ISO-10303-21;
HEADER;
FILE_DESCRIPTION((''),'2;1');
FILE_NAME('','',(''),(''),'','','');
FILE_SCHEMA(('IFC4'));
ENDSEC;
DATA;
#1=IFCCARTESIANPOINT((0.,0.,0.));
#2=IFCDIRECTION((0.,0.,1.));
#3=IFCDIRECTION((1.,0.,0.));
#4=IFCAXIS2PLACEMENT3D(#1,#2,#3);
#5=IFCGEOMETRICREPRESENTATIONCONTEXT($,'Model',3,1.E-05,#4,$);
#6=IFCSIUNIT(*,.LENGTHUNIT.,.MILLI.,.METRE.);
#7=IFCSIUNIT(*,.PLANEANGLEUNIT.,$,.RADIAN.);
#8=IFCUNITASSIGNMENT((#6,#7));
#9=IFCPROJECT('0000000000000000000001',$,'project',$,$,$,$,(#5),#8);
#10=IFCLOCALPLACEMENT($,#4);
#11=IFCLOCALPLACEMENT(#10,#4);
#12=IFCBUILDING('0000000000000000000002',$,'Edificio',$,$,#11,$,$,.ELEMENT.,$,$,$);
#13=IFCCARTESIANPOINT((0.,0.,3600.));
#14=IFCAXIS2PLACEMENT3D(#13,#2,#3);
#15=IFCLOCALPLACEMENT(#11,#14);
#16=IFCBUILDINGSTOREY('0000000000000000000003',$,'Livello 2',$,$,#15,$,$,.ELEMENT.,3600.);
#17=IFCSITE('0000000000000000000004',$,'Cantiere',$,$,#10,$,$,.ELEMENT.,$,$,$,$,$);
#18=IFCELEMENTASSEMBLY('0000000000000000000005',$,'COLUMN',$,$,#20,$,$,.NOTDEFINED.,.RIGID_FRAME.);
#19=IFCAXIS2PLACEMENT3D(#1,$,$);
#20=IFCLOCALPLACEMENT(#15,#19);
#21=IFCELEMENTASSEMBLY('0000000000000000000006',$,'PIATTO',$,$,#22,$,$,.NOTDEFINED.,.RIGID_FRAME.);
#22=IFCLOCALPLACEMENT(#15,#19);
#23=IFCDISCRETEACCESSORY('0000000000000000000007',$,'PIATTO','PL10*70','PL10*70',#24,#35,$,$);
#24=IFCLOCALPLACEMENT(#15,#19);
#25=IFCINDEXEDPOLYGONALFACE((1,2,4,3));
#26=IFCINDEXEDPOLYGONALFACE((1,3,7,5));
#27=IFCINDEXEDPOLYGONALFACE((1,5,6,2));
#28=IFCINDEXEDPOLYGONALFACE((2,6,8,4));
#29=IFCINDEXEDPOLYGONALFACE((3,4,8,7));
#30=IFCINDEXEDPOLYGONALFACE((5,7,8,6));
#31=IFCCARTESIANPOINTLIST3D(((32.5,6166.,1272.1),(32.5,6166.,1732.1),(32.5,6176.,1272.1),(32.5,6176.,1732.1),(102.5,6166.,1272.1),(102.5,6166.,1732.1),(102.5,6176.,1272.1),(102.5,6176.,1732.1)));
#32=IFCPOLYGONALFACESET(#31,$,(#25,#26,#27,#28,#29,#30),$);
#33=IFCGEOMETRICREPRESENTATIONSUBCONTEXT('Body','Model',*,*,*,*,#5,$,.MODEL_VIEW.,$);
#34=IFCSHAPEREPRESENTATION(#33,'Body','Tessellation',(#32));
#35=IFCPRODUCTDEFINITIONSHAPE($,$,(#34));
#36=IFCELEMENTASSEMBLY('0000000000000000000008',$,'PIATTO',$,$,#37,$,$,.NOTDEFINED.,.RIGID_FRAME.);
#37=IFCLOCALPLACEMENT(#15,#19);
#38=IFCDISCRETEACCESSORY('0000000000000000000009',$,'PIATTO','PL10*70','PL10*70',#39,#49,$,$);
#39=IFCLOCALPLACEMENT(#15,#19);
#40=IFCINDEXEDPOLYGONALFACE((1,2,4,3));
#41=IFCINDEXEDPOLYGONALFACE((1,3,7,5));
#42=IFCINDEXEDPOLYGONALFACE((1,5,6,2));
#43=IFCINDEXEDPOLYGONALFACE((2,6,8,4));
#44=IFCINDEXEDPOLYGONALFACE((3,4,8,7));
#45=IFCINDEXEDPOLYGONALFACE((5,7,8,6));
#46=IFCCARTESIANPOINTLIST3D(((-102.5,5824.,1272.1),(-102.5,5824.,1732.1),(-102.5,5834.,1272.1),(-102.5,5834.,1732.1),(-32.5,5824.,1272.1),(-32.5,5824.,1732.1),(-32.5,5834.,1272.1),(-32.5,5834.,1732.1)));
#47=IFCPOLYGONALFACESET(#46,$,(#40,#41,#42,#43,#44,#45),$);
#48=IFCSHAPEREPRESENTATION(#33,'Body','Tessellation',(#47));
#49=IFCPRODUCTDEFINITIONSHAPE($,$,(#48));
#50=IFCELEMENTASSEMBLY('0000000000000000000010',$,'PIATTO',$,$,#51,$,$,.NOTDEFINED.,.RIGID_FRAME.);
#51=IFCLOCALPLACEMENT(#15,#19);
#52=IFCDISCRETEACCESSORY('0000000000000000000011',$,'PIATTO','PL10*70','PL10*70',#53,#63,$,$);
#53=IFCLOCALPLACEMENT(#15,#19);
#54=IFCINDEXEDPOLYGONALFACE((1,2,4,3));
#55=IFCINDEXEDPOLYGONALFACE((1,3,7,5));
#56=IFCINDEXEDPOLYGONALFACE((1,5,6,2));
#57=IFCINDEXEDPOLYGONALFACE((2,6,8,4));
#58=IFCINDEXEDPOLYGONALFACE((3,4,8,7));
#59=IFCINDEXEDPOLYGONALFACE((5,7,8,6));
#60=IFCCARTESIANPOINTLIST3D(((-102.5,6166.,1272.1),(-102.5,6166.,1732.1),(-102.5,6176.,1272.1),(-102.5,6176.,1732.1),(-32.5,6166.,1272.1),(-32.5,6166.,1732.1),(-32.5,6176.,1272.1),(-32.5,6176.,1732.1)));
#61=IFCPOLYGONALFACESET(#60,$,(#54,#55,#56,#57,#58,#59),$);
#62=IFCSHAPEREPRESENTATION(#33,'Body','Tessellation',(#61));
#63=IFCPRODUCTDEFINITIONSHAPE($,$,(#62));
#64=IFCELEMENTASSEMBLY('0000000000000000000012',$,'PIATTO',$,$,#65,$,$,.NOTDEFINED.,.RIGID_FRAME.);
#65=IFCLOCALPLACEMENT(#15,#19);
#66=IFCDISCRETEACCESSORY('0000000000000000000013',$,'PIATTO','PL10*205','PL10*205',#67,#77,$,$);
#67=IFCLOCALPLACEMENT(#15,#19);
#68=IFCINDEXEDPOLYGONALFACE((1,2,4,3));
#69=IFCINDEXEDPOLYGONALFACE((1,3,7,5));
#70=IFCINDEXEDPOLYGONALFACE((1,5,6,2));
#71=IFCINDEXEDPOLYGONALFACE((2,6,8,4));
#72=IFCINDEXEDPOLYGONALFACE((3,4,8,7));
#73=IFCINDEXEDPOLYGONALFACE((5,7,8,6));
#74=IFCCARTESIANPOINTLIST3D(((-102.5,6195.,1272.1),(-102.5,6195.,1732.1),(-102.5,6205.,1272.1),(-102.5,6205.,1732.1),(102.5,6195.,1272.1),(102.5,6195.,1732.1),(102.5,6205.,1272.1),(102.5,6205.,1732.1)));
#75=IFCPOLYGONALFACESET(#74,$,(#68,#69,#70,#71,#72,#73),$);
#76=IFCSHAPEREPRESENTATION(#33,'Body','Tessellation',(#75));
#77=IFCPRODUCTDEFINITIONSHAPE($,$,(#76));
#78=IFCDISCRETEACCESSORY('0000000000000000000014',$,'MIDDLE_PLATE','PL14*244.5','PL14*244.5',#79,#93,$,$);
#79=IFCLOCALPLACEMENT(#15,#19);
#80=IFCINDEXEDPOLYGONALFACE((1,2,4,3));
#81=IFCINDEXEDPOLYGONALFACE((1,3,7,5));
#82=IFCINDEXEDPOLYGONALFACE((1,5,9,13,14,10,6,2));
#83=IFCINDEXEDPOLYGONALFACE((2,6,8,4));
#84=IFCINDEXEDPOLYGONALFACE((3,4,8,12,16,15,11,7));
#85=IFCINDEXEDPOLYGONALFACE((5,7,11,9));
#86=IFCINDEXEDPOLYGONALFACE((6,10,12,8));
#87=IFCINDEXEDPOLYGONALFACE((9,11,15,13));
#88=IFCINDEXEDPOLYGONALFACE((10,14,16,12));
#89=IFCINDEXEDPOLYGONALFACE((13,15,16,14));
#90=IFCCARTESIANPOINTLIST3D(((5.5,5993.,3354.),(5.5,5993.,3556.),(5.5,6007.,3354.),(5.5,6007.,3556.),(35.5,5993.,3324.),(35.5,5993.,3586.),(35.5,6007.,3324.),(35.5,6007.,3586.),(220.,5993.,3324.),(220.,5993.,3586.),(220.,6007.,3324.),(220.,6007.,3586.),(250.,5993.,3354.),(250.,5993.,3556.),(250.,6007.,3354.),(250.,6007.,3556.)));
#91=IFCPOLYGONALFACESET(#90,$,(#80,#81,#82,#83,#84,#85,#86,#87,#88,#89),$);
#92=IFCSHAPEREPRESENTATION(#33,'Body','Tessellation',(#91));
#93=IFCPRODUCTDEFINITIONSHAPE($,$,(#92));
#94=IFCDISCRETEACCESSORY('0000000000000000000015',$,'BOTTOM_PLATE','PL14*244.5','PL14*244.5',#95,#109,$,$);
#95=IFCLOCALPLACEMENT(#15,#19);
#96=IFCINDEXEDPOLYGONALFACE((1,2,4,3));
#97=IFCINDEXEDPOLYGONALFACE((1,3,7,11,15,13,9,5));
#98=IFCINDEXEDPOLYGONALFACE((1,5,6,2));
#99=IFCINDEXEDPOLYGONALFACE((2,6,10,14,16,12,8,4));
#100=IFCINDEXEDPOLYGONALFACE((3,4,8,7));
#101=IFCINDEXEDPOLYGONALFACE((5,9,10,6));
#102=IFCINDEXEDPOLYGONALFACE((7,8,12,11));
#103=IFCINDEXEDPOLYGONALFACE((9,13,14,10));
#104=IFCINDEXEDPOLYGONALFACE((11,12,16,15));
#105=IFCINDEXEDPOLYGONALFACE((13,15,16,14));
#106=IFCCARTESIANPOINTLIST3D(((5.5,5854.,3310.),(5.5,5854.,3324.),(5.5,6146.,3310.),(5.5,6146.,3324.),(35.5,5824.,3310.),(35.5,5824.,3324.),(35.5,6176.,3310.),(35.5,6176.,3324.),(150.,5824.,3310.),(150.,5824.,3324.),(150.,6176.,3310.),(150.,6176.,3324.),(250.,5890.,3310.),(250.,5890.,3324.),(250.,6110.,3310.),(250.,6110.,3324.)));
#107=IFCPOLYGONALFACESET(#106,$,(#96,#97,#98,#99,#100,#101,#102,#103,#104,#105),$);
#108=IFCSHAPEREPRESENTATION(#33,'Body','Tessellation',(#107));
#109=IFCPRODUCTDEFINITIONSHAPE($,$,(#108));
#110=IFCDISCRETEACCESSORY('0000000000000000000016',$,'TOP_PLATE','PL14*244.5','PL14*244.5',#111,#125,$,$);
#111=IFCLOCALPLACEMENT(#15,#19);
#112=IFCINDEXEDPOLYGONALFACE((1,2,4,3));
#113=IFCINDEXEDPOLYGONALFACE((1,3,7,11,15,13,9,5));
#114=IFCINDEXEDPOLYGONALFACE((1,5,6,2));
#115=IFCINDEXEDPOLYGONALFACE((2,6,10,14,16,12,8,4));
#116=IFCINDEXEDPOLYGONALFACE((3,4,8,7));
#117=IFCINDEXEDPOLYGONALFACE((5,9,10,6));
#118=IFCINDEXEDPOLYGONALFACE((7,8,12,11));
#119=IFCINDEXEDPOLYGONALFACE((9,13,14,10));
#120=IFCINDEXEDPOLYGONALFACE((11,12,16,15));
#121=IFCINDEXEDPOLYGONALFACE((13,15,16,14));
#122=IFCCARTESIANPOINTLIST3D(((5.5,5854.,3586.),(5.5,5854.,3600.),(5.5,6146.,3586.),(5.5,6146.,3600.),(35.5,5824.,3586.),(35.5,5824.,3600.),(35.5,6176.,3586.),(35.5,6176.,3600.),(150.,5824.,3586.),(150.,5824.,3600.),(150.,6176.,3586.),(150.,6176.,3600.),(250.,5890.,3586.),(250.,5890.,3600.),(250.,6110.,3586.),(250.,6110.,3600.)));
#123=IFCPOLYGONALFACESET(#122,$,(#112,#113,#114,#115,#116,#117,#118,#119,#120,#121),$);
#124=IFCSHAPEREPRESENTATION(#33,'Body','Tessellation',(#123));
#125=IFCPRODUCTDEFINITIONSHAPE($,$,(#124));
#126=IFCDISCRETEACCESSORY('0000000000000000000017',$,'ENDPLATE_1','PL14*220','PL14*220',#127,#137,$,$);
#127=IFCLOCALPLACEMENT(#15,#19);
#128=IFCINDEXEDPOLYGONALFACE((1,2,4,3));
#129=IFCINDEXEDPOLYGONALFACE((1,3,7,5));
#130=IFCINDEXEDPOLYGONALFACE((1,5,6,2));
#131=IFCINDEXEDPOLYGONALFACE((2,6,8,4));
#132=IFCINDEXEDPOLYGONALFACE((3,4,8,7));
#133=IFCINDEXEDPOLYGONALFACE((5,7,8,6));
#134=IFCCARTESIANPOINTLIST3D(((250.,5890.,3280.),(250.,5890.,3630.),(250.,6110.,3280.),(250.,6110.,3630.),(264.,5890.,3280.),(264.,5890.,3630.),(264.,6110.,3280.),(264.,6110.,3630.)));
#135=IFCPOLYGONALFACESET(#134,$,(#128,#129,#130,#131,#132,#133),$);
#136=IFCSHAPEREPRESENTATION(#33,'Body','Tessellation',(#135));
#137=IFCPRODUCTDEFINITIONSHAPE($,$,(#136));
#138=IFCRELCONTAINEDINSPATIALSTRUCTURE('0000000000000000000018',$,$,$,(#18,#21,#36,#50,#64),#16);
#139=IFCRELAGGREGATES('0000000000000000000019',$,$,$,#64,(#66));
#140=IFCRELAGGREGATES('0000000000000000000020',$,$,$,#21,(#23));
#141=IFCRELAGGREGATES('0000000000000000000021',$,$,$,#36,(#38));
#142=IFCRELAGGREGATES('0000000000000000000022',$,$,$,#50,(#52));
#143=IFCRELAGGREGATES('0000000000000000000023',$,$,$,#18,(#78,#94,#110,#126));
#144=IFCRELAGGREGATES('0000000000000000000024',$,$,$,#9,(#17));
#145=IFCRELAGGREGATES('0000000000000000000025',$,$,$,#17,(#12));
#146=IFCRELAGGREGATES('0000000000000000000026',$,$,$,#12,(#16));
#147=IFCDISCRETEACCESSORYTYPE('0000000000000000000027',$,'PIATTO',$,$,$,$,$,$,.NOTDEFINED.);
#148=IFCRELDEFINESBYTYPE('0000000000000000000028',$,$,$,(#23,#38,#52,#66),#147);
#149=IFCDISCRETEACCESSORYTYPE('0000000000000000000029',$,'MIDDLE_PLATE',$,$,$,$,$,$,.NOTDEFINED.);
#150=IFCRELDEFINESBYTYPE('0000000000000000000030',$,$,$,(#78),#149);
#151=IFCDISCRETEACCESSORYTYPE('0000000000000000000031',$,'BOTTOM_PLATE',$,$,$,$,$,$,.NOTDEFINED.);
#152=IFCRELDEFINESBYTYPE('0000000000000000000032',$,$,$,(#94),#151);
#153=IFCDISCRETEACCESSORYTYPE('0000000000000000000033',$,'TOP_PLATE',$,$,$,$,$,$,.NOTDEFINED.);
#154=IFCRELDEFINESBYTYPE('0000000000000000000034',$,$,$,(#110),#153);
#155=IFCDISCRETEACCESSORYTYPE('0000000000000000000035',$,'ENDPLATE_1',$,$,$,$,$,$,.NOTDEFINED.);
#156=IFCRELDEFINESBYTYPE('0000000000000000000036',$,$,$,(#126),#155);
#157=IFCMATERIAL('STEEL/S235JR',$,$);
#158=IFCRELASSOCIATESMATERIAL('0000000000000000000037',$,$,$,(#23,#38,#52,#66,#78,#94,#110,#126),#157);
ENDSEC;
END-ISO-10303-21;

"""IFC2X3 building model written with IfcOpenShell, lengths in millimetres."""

from ifc_helpers import new_model, si_unit, frame, origin_with_axes, place, context, subcontext, project, spatial, polyline, outline, extrude, material, type_object, element, aggregate, save


model = new_model("IFC2X3")

# Units and contexts
model_context = context("Model", 3, precision=1e-05, world=origin_with_axes())
body_context = subcontext(model_context, "Body", "Model", "MODEL_VIEW")
ifc_project = project(units=[si_unit("LENGTHUNIT", "METRE", prefix="MILLI"), si_unit("PLANEANGLEUNIT", "RADIAN")], contexts=[model_context])

# Site, building, storey
site_placement = place(None, origin_with_axes())
site = spatial("IfcSite", under=ifc_project, at=site_placement, Name="Cantiere", CompositionType="ELEMENT")
building_placement = place(site_placement, origin_with_axes())
building = spatial("IfcBuilding", under=site, at=building_placement, Name="Edificio", CompositionType="ELEMENT")
storey_placement = place(building_placement, frame((0.0, 0.0, 3600.0), z_axis=(0.0, 0.0, 1.0), x_axis=(1.0, 0.0, 0.0)))
storey = spatial("IfcBuildingStorey", under=building, at=storey_placement, Name="Livello 2", CompositionType="ELEMENT", Elevation=3600.0)

# Element assembly
assembly_1_placement = place(storey_placement, origin_with_axes())
assembly_1 = element("IfcElementAssembly", 1, at=assembly_1_placement, inside=storey, Name="COLUMN", AssemblyPlace="NOTDEFINED", PredefinedType="RIGID_FRAME")
ifc_material_1 = material(Name="STEEL/S235JR")

# Shared definitions
discrete_accessory_type_1 = type_object("IfcDiscreteAccessoryType", Name="PIATTO")

# Element assemblies, discrete accessories
assembly_2_placement = place(storey_placement, origin_with_axes())
assembly_2 = element("IfcElementAssembly", 2, at=assembly_2_placement, inside=storey, Name="PIATTO", AssemblyPlace="NOTDEFINED", PredefinedType="RIGID_FRAME")
discrete_accessory_1_placement = place(assembly_2_placement, frame((67.5, 6171.0, 1732.1), z_axis=(0.0, 1.0, 0.0), x_axis=(0.0, 0.0, -1.0)))
discrete_accessory_1 = element("IfcDiscreteAccessory", 3, at=discrete_accessory_1_placement, type_object=discrete_accessory_type_1, material=ifc_material_1, Name="PIATTO", Description="PL10*70", ObjectType="PL10*70", context=body_context, shape_type="SweptSolid", body=[
    extrude(outline(polyline([(460.0, 35.0), (460.0, -35.0), (0.0, -35.0), (0.0, 35.0), (460.0, 35.0)])), frame((0.0, 0.0, -5.0), z_axis=(0.0, 0.0, 1.0), x_axis=(1.0, 0.0, 0.0)), (0.0, 0.0, 1.0), 10.0),
])
assembly_3_placement = place(storey_placement, origin_with_axes())
assembly_3 = element("IfcElementAssembly", 4, at=assembly_3_placement, inside=storey, Name="PIATTO", AssemblyPlace="NOTDEFINED", PredefinedType="RIGID_FRAME")
discrete_accessory_2_placement = place(assembly_3_placement, frame((-67.5, 5829.0, 1732.1), z_axis=(0.0, 1.0, 0.0), x_axis=(0.0, 0.0, -1.0)))
discrete_accessory_2 = element("IfcDiscreteAccessory", 5, at=discrete_accessory_2_placement, type_object=discrete_accessory_type_1, material=ifc_material_1, Name="PIATTO", Description="PL10*70", ObjectType="PL10*70", context=body_context, shape_type="SweptSolid", body=[
    extrude(outline(polyline([(460.0, 35.0), (460.0, -35.0), (0.0, -35.0), (0.0, 35.0), (460.0, 35.0)])), frame((0.0, 0.0, -5.0), z_axis=(0.0, 0.0, 1.0), x_axis=(1.0, 0.0, 0.0)), (0.0, 0.0, 1.0), 10.0),
])
assembly_4_placement = place(storey_placement, origin_with_axes())
assembly_4 = element("IfcElementAssembly", 6, at=assembly_4_placement, inside=storey, Name="PIATTO", AssemblyPlace="NOTDEFINED", PredefinedType="RIGID_FRAME")
discrete_accessory_3_placement = place(assembly_4_placement, frame((-67.5, 6171.0, 1732.1), z_axis=(0.0, 1.0, 0.0), x_axis=(0.0, 0.0, -1.0)))
discrete_accessory_3 = element("IfcDiscreteAccessory", 7, at=discrete_accessory_3_placement, type_object=discrete_accessory_type_1, material=ifc_material_1, Name="PIATTO", Description="PL10*70", ObjectType="PL10*70", context=body_context, shape_type="SweptSolid", body=[
    extrude(outline(polyline([(460.0, 35.0), (460.0, -35.0), (0.0, -35.0), (0.0, 35.0), (460.0, 35.0)])), frame((0.0, 0.0, -5.0), z_axis=(0.0, 0.0, 1.0), x_axis=(1.0, 0.0, 0.0)), (0.0, 0.0, 1.0), 10.0),
])
assembly_5_placement = place(storey_placement, origin_with_axes())
assembly_5 = element("IfcElementAssembly", 8, at=assembly_5_placement, inside=storey, Name="PIATTO", AssemblyPlace="NOTDEFINED", PredefinedType="RIGID_FRAME")
discrete_accessory_4_placement = place(assembly_5_placement, frame((0.0, 6200.0, 1272.1), z_axis=(0.0, -1.0, 0.0), x_axis=(0.0, 0.0, 1.0)))
discrete_accessory_4 = element("IfcDiscreteAccessory", 9, at=discrete_accessory_4_placement, type_object=discrete_accessory_type_1, material=ifc_material_1, Name="PIATTO", Description="PL10*205", ObjectType="PL10*205", context=body_context, shape_type="SweptSolid", body=[
    extrude(outline(polyline([(0.0, 102.5), (460.0, 102.5), (460.0, -102.5), (0.0, -102.5), (0.0, 102.5)])), frame((0.0, 0.0, -5.0), z_axis=(0.0, 0.0, 1.0), x_axis=(1.0, 0.0, 0.0)), (0.0, 0.0, 1.0), 10.0),
])
aggregate(assembly_5, [discrete_accessory_4])

aggregate(assembly_2, [discrete_accessory_1])
aggregate(assembly_3, [discrete_accessory_2])
aggregate(assembly_4, [discrete_accessory_3])

# Discrete accessories
discrete_accessory_type_2 = type_object("IfcDiscreteAccessoryType", Name="MIDDLE_PLATE")
discrete_accessory_5_placement = place(assembly_1_placement, frame((250.0, 6000.0, 3586.0), z_axis=(0.0, -1.0, 0.0), x_axis=(-1.0, 0.0, 0.0)))
discrete_accessory_5 = element("IfcDiscreteAccessory", 10, at=discrete_accessory_5_placement, type_object=discrete_accessory_type_2, material=ifc_material_1, Name="MIDDLE_PLATE", Description="PL14*244.5", ObjectType="PL14*244.5", context=body_context, shape_type="SweptSolid", body=[
    extrude(outline(polyline([(0.0, 30.0), (30.0, 0.0), (214.5, 0.0), (244.5, 30.0), (244.5, 232.0), (214.5, 262.0), (30.0, 262.0), (0.0, 232.0), (0.0, 30.0)])), frame((0.0, 0.0, -7.0), z_axis=(0.0, 0.0, 1.0), x_axis=(1.0, 0.0, 0.0)), (0.0, 0.0, 1.0), 14.0),
])
discrete_accessory_type_3 = type_object("IfcDiscreteAccessoryType", Name="BOTTOM_PLATE")
discrete_accessory_6_placement = place(assembly_1_placement, frame((5.5, 6176.0, 3317.0), z_axis=(0.0, 0.0, 1.0), x_axis=(0.0, -1.0, 0.0)))
discrete_accessory_6 = element("IfcDiscreteAccessory", 11, at=discrete_accessory_6_placement, type_object=discrete_accessory_type_3, material=ifc_material_1, Name="BOTTOM_PLATE", Description="PL14*244.5", ObjectType="PL14*244.5", context=body_context, shape_type="SweptSolid", body=[
    extrude(outline(polyline([(0.0, 30.0), (30.0, 0.0), (322.0, 0.0), (352.0, 30.0), (352.0, 144.5), (286.0, 244.5), (66.0, 244.5), (0.0, 144.5), (0.0, 30.0)])), frame((0.0, 0.0, -7.0), z_axis=(0.0, 0.0, 1.0), x_axis=(1.0, 0.0, 0.0)), (0.0, 0.0, 1.0), 14.0),
])
discrete_accessory_type_4 = type_object("IfcDiscreteAccessoryType", Name="TOP_PLATE")
discrete_accessory_7_placement = place(assembly_1_placement, frame((150.0, 6176.0, 3593.0), z_axis=(0.0, 0.0, 1.0), x_axis=(-1.0, 0.0, 0.0)))
discrete_accessory_7 = element("IfcDiscreteAccessory", 12, at=discrete_accessory_7_placement, type_object=discrete_accessory_type_4, material=ifc_material_1, Name="TOP_PLATE", Description="PL14*244.5", ObjectType="PL14*244.5", context=body_context, shape_type="SweptSolid", body=[
    extrude(outline(polyline([(0.0, 0.0), (114.5, 0.0), (144.5, 30.0), (144.5, 322.0), (114.5, 352.0), (0.0, 352.0), (-100.0, 286.0), (-100.0, 66.0), (0.0, 0.0)])), frame((0.0, 0.0, -7.0), z_axis=(0.0, 0.0, 1.0), x_axis=(1.0, 0.0, 0.0)), (0.0, 0.0, 1.0), 14.0),
])
discrete_accessory_type_5 = type_object("IfcDiscreteAccessoryType", Name="ENDPLATE_1")
discrete_accessory_8_placement = place(assembly_1_placement, frame((257.0, 6110.0, 3280.0), z_axis=(1.0, 0.0, 0.0), x_axis=(0.0, 0.0, 1.0)))
discrete_accessory_8 = element("IfcDiscreteAccessory", 13, at=discrete_accessory_8_placement, type_object=discrete_accessory_type_5, material=ifc_material_1, Name="ENDPLATE_1", Description="PL14*220", ObjectType="PL14*220", context=body_context, shape_type="SweptSolid", body=[
    extrude(outline(polyline([(0.0, 0.0), (350.0, 0.0), (350.0, 220.0), (0.0, 220.0), (0.0, 0.0)])), frame((0.0, 0.0, -7.0), z_axis=(0.0, 0.0, 1.0), x_axis=(1.0, 0.0, 0.0)), (0.0, 0.0, 1.0), 14.0),
])
aggregate(assembly_1, [discrete_accessory_5, discrete_accessory_6, discrete_accessory_7, discrete_accessory_8])

save(model, "model.ifc")
